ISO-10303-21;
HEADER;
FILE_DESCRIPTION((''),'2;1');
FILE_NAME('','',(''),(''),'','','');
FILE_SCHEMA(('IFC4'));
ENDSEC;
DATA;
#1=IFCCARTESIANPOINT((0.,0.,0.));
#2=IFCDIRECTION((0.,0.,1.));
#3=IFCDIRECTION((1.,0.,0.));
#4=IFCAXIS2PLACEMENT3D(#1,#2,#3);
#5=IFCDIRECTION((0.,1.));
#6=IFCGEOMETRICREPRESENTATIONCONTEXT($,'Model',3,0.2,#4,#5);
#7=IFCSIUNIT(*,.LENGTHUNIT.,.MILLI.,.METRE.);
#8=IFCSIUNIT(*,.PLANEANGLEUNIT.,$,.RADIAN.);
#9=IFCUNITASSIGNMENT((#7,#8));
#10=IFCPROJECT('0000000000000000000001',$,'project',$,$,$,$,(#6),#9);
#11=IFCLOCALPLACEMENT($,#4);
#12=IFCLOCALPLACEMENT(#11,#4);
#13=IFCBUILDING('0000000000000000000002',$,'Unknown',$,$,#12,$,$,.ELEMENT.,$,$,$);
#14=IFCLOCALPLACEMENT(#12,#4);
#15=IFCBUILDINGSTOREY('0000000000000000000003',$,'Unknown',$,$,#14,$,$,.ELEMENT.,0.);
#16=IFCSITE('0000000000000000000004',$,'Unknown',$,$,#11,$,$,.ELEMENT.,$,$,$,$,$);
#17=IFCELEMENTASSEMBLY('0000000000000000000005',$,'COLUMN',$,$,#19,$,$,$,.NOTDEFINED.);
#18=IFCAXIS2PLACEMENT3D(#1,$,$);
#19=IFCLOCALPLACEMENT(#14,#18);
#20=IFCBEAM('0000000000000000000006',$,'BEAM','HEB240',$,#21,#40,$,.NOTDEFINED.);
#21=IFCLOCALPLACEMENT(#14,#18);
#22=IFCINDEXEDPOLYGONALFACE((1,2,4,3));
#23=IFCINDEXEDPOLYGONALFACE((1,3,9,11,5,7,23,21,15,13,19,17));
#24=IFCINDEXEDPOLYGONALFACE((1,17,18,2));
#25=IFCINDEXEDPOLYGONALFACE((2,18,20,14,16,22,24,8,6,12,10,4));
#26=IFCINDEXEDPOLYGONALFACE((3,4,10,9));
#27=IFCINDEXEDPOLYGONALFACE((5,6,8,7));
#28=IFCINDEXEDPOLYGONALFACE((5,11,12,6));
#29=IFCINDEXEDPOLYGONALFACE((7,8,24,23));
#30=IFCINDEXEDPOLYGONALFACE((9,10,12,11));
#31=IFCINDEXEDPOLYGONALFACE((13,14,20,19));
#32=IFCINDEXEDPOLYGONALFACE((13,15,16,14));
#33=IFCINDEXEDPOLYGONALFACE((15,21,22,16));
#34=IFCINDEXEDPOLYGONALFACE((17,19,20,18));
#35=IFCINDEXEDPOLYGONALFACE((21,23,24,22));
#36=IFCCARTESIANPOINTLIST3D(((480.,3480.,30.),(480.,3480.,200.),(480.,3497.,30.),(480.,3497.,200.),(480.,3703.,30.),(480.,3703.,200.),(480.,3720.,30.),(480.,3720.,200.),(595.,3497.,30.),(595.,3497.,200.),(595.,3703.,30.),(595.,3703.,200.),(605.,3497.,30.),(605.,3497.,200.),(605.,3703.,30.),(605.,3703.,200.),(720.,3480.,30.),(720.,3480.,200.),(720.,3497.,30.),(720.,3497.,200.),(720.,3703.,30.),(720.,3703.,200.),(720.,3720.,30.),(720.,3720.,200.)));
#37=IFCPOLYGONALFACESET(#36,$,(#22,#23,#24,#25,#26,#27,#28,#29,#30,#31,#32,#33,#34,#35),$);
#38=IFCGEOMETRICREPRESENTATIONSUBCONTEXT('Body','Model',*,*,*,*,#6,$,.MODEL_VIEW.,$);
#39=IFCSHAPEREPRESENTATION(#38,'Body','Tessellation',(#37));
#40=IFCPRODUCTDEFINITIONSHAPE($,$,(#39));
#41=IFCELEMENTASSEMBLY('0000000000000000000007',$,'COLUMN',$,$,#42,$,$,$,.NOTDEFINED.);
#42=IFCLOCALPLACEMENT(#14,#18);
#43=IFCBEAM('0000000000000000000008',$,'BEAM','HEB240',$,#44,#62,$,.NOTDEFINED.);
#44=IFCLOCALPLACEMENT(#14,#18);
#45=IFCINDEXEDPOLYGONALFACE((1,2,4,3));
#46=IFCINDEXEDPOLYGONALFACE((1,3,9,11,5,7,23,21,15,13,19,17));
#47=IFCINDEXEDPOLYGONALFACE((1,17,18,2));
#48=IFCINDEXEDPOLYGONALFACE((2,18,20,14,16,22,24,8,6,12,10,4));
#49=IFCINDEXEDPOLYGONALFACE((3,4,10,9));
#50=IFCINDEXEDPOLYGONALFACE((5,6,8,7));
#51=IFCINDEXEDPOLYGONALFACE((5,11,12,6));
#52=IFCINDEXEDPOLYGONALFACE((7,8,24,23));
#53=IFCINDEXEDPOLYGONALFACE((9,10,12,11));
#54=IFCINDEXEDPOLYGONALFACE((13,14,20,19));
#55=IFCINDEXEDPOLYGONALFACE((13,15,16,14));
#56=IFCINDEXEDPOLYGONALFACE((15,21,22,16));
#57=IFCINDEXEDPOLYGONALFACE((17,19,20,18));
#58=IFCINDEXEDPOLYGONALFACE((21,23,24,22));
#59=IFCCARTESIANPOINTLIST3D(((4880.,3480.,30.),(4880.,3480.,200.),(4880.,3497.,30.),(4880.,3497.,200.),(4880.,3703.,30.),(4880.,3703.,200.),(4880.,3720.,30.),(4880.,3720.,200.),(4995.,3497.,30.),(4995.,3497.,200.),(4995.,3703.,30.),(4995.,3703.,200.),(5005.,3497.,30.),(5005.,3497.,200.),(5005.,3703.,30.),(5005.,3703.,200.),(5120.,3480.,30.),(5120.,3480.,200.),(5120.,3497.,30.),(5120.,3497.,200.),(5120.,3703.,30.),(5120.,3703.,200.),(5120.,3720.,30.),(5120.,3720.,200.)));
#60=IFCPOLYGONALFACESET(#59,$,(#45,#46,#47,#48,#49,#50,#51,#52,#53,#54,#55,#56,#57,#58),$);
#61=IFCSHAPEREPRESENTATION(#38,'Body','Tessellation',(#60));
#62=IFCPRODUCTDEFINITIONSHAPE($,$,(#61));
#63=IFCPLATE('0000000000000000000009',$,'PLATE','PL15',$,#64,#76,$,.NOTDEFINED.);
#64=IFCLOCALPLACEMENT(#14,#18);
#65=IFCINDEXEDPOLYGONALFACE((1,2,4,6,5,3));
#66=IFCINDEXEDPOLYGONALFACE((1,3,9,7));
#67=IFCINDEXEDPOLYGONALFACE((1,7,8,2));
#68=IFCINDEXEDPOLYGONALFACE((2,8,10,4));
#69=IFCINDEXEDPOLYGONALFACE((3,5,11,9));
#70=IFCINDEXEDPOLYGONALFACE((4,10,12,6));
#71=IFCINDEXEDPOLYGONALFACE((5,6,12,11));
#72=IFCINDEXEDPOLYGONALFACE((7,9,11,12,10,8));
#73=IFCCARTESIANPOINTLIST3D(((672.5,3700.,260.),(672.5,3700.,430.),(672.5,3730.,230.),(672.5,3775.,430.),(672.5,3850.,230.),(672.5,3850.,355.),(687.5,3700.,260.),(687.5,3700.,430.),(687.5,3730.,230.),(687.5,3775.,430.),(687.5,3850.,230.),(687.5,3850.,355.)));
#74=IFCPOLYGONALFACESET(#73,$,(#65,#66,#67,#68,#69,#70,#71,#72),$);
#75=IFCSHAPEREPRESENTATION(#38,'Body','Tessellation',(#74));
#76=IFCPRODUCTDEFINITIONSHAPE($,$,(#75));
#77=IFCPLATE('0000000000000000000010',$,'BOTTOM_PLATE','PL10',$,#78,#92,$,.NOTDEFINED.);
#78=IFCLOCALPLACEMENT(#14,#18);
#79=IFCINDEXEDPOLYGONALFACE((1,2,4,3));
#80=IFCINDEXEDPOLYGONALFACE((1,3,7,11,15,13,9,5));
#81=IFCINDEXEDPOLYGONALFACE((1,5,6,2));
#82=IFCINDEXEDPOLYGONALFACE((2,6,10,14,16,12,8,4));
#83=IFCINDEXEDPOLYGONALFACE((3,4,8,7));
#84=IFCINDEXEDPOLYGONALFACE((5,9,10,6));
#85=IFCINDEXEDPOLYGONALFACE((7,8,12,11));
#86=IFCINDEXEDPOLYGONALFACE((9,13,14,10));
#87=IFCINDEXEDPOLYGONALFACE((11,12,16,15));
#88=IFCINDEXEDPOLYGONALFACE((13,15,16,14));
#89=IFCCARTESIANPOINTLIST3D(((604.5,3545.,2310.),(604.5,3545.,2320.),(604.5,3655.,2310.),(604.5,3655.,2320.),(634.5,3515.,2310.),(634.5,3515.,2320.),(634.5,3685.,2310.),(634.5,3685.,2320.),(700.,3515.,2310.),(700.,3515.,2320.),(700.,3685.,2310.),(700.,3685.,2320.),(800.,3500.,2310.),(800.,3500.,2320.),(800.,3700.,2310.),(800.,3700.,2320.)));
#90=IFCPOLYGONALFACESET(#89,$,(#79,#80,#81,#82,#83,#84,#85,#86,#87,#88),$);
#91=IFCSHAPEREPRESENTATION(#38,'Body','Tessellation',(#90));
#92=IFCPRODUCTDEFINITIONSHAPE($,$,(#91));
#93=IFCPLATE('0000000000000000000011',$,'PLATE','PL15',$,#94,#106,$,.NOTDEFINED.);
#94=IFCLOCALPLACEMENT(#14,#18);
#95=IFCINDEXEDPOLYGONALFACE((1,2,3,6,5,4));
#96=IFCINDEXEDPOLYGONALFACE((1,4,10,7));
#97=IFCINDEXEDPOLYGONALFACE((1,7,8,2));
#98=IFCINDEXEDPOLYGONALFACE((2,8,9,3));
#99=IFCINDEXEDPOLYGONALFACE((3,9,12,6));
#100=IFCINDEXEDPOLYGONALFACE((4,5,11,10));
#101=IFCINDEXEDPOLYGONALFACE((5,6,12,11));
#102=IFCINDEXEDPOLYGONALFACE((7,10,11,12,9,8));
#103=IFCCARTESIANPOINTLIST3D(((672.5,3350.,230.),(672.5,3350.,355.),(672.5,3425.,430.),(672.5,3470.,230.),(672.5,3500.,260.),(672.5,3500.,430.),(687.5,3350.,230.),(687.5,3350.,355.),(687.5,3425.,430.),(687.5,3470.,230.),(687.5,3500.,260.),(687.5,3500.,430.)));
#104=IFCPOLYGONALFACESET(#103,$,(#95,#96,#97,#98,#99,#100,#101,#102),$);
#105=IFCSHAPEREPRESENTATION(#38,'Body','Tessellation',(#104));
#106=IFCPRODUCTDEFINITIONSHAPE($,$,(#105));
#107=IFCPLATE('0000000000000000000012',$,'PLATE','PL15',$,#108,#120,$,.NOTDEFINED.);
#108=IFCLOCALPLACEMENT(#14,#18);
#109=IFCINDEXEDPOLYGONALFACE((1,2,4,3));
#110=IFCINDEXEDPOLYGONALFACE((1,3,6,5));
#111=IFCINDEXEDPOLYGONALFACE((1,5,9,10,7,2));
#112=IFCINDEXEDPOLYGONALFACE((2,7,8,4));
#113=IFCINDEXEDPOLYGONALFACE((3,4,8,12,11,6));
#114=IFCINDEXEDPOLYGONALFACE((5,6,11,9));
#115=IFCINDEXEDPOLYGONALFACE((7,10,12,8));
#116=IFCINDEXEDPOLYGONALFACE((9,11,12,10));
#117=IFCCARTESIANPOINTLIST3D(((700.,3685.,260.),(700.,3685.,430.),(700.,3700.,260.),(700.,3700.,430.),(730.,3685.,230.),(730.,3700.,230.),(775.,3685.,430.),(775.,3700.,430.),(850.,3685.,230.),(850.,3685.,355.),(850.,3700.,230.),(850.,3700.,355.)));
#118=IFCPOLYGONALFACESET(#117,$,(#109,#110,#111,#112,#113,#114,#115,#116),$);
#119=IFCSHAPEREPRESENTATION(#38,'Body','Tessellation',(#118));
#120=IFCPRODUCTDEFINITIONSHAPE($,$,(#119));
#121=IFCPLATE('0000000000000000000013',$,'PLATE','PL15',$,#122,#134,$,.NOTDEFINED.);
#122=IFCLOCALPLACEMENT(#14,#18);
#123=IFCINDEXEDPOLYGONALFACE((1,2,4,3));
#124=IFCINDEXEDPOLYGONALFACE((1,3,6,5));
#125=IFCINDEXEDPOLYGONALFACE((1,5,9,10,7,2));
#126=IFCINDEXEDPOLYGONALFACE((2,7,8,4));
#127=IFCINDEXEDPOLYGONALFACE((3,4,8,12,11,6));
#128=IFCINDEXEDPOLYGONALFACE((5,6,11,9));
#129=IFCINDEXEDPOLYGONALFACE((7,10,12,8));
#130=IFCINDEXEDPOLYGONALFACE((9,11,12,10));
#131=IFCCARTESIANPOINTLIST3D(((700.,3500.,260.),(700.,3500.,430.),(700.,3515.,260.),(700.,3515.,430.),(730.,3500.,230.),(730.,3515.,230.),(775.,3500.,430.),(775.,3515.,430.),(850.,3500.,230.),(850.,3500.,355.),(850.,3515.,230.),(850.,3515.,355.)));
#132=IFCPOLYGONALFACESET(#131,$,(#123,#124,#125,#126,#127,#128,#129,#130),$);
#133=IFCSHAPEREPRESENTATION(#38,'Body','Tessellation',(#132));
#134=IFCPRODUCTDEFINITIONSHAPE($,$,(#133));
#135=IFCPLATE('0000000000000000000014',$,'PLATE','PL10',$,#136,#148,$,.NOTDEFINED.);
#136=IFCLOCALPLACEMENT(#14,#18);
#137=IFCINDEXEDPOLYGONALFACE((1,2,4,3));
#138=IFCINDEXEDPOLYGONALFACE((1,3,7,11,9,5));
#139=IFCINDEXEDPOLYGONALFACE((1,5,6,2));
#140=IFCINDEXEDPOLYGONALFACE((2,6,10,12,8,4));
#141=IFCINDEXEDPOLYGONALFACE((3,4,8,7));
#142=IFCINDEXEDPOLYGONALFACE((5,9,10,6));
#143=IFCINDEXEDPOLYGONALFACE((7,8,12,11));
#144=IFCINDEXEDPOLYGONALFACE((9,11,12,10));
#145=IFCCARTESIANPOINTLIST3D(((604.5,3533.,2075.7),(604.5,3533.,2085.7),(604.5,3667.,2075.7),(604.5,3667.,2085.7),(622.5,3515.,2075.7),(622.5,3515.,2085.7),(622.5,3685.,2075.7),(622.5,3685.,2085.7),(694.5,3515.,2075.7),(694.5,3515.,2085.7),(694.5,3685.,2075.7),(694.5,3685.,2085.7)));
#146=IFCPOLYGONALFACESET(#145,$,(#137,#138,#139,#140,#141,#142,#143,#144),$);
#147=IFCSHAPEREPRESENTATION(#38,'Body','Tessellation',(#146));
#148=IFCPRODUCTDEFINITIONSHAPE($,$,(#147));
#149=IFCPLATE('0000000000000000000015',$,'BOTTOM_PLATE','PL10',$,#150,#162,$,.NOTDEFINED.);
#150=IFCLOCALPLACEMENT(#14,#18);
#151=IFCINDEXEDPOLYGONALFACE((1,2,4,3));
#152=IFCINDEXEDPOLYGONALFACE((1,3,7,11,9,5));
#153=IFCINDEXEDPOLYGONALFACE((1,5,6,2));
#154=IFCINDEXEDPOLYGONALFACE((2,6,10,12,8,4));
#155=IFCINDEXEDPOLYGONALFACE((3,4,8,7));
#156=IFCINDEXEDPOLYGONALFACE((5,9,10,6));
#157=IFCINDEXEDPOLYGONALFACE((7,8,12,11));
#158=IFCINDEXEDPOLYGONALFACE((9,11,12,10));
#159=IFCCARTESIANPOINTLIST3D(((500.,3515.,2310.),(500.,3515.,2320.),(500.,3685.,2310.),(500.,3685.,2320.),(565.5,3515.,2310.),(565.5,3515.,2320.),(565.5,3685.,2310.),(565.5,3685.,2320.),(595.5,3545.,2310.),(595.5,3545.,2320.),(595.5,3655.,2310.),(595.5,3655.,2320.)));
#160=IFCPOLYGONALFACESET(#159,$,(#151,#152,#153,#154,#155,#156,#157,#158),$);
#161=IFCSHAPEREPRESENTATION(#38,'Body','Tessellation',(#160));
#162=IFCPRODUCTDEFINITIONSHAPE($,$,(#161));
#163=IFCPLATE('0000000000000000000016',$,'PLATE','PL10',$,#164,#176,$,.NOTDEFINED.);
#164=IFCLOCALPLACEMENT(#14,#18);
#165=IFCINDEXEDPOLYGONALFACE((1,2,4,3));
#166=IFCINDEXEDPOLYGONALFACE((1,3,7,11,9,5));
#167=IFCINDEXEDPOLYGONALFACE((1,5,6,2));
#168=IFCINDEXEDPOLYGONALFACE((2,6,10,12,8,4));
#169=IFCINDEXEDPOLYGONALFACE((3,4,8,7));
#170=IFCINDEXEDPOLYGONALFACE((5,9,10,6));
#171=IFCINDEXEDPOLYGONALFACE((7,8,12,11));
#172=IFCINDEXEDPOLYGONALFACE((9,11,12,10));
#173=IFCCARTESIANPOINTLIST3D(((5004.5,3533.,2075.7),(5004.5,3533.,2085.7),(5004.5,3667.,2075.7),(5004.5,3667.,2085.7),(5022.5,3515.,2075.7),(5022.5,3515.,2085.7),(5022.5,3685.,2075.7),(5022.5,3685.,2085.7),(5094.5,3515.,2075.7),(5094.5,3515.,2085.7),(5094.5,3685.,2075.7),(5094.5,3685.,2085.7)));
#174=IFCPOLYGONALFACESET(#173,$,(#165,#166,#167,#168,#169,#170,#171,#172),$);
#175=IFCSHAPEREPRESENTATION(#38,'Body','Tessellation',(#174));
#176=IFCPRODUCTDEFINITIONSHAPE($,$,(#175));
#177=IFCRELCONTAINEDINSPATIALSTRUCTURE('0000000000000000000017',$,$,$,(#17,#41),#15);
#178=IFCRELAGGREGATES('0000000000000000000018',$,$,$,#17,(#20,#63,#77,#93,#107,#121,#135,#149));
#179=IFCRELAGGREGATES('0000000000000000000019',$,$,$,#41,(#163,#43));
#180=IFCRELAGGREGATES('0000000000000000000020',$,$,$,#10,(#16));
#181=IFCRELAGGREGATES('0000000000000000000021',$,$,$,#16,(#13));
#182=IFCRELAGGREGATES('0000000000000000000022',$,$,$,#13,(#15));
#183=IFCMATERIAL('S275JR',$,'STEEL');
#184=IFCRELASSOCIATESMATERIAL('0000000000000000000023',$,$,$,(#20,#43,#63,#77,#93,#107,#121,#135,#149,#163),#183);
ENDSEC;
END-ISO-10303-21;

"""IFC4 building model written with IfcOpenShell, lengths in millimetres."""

from ifc_helpers import new_model, si_unit, direction, frame, origin_with_axes, place, context, subcontext, project, spatial, line, indexed_curve, outline, extrude, material, element, aggregate, save


model = new_model("IFC4")

# Units and contexts
model_context = context("Model", 3, precision=0.2, world=origin_with_axes(), true_north=direction((0.0, 1.0)))
body_context = subcontext(model_context, "Body", "Model", "MODEL_VIEW")
ifc_project = project(units=[si_unit("LENGTHUNIT", "METRE", prefix="MILLI"), si_unit("PLANEANGLEUNIT", "RADIAN")], contexts=[model_context])

# Site, building, storey
site_placement = place(None, origin_with_axes())
site = spatial("IfcSite", under=ifc_project, at=site_placement, Name="Unknown", CompositionType="ELEMENT")
building_placement = place(site_placement, origin_with_axes())
building = spatial("IfcBuilding", under=site, at=building_placement, Name="Unknown", CompositionType="ELEMENT")
storey_placement = place(building_placement, origin_with_axes())
storey = spatial("IfcBuildingStorey", under=building, at=storey_placement, Name="Unknown", CompositionType="ELEMENT", Elevation=0.0)

# Element assemblies, beams
assembly_1_placement = place(storey_placement, frame((600.0, 3600.0, 200.0), z_axis=(-1.0, 0.0, 0.0), x_axis=(0.0, 0.0, 1.0)))
assembly_1 = element("IfcElementAssembly", 1, at=assembly_1_placement, inside=storey, Name="COLUMN", PredefinedType="NOTDEFINED")
ifc_material_1 = material(Name="S275JR", Category="STEEL")
beam_1_placement = place(assembly_1_placement, frame((0.0, 0.0, 0.0), z_axis=(0.0, -0.000002, -1.0), x_axis=(-1.0, 0.0, 0.0)))
beam_1 = element("IfcBeam", 2, at=beam_1_placement, material=ifc_material_1, Name="BEAM", Description="HEB240", PredefinedType="NOTDEFINED", context=body_context, shape_type="SolidModel", body=[
    extrude(outline(indexed_curve([(-120.0, -120.0), (120.0, -120.0), (120.0, -103.0), (5.0, -103.0), (5.0, 103.0), (120.0, 103.0), (120.0, 120.0), (-120.0, 120.0), (-120.0, 103.0), (-5.0, 103.0), (-5.0, -103.0), (-120.0, -103.0)], segments=[line(1, 2, 3, 4, 5, 6, 7, 8, 9, 10, 11, 12, 1)])), frame((0.0, 0.0, 0.0), z_axis=(-1.0, 0.0, 0.0), x_axis=(0.0, 0.0, 1.0)), (0.0, -0.000002, -1.0), 170.0),
])
assembly_2_placement = place(storey_placement, frame((5000.0, 3600.0, 200.0), z_axis=(-1.0, 0.0, 0.0), x_axis=(0.0, 0.0, 1.0)))
assembly_2 = element("IfcElementAssembly", 3, at=assembly_2_placement, inside=storey, Name="COLUMN", PredefinedType="NOTDEFINED")
beam_2_placement = place(assembly_2_placement, frame((0.0, 0.0, 0.0), z_axis=(0.0, -0.000002, -1.0), x_axis=(-1.0, 0.0, 0.0)))
beam_2 = element("IfcBeam", 4, at=beam_2_placement, material=ifc_material_1, Name="BEAM", Description="HEB240", PredefinedType="NOTDEFINED", context=body_context, shape_type="SolidModel", body=[
    extrude(outline(indexed_curve([(-120.0, -120.0), (120.0, -120.0), (120.0, -103.0), (5.0, -103.0), (5.0, 103.0), (120.0, 103.0), (120.0, 120.0), (-120.0, 120.0), (-120.0, 103.0), (-5.0, 103.0), (-5.0, -103.0), (-120.0, -103.0)], segments=[line(1, 2, 3, 4, 5, 6, 7, 8, 9, 10, 11, 12, 1)])), frame((0.0, 0.0, 0.0), z_axis=(-1.0, 0.0, 0.0), x_axis=(0.0, 0.0, 1.0)), (0.0, -0.000002, -1.0), 170.0),
])

# Plates
plate_1_placement = place(assembly_1_placement, frame((60.0, 100.0, -80.0), z_axis=(0.0, -0.000002, -1.0), x_axis=(-0.707113, 0.707101, 0.0)))
plate_1 = element("IfcPlate", 5, at=plate_1_placement, material=ifc_material_1, Name="PLATE", Description="PL15", PredefinedType="NOTDEFINED", context=body_context, shape_type="SolidModel", body=[
    extrude(outline(indexed_curve([(0.0, 0.0), (42.4, 0.0), (127.3, 84.9), (38.9, 173.2), (-67.2, 173.2), (-120.2, 120.2)], segments=[line(1, 2, 3, 4, 5, 6, 1)])), frame((0.0, 0.0, 7.5), z_axis=(0.0, 0.0, 1.0), x_axis=(1.0, 0.0, 0.0)), (0.0, -0.000002, -1.0), 15.0),
])
plate_2_placement = place(assembly_1_placement, frame((2115.0, 85.0, -4.5), z_axis=(1.0, 0.0, 0.0), x_axis=(0.0, -1.0, 0.000002)))
plate_2 = element("IfcPlate", 6, at=plate_2_placement, material=ifc_material_1, Name="BOTTOM_PLATE", Description="PL10", PredefinedType="NOTDEFINED", context=body_context, shape_type="SolidModel", body=[
    extrude(outline(indexed_curve([(0.0, 30.0), (30.0, 0.0), (140.0, 0.0), (170.0, 30.0), (170.0, 95.5), (185.0, 195.5), (-15.0, 195.5), (0.0, 95.5)], segments=[line(1, 2, 3, 4, 5, 6, 7, 8, 1)])), frame((0.0, 0.0, 5.0), z_axis=(0.0, 0.0, 1.0), x_axis=(1.0, 0.0, 0.0)), (0.0, -0.000002, -1.0), 10.0),
])
plate_3_placement = place(assembly_1_placement, frame((60.0, -100.0, -80.0), z_axis=(0.0, 0.0, 1.0), x_axis=(-0.707116, -0.707097, 0.0)))
plate_3 = element("IfcPlate", 7, at=plate_3_placement, material=ifc_material_1, Name="PLATE", Description="PL15", PredefinedType="NOTDEFINED", context=body_context, shape_type="SolidModel", body=[
    extrude(outline(indexed_curve([(0.0, 0.0), (42.4, 0.0), (127.3, 84.9), (38.9, 173.2), (-67.2, 173.2), (-120.2, 120.2)], segments=[line(1, 2, 3, 4, 5, 6, 1)])), frame((0.0, 0.0, 7.5), z_axis=(0.0, 0.0, 1.0), x_axis=(1.0, 0.0, 0.0)), (0.0, -0.000002, -1.0), 15.0),
])
plate_4_placement = place(assembly_1_placement, frame((60.0, 92.5, -100.0), z_axis=(0.0, -1.0, 0.000002), x_axis=(-0.707107, 0.0, -0.707107)))
plate_4 = element("IfcPlate", 8, at=plate_4_placement, material=ifc_material_1, Name="PLATE", Description="PL15", PredefinedType="NOTDEFINED", context=body_context, shape_type="SolidModel", body=[
    extrude(outline(indexed_curve([(0.0, 0.0), (42.4, 0.0), (127.3, 84.9), (38.9, 173.2), (-67.2, 173.2), (-120.2, 120.2)], segments=[line(1, 2, 3, 4, 5, 6, 1)])), frame((0.0, 0.0, 7.5), z_axis=(0.0, 0.0, 1.0), x_axis=(1.0, 0.0, 0.0)), (0.0, -0.000002, -1.0), 15.0),
])
plate_5_placement = place(assembly_1_placement, frame((60.0, -92.5, -100.0), z_axis=(0.0, -1.0, 0.000002), x_axis=(-0.707107, 0.0, -0.707107)))
plate_5 = element("IfcPlate", 9, at=plate_5_placement, material=ifc_material_1, Name="PLATE", Description="PL15", PredefinedType="NOTDEFINED", context=body_context, shape_type="SolidModel", body=[
    extrude(outline(indexed_curve([(0.0, 0.0), (42.4, 0.0), (127.3, 84.9), (38.9, 173.2), (-67.2, 173.2), (-120.2, 120.2)], segments=[line(1, 2, 3, 4, 5, 6, 1)])), frame((0.0, 0.0, 7.5), z_axis=(0.0, 0.0, 1.0), x_axis=(1.0, 0.0, 0.0)), (0.0, -0.000002, -1.0), 15.0),
])
plate_6_placement = place(assembly_1_placement, frame((1880.7, -85.0, -94.5), z_axis=(-1.0, 0.0, 0.0), x_axis=(0.0, 0.0, 1.0)))
plate_6 = element("IfcPlate", 10, at=plate_6_placement, material=ifc_material_1, Name="PLATE", Description="PL10", PredefinedType="NOTDEFINED", context=body_context, shape_type="SolidModel", body=[
    extrude(outline(indexed_curve([(0.0, 0.0), (72.0, 0.0), (90.0, 18.0), (90.0, 152.0), (72.0, 170.0), (0.0, 170.0)], segments=[line(1, 2, 3, 4, 5, 6, 1)])), frame((0.0, 0.0, 5.0), z_axis=(0.0, 0.0, 1.0), x_axis=(1.0, 0.0, 0.0)), (0.0, -0.000002, -1.0), 10.0),
])
plate_7_placement = place(assembly_1_placement, frame((2115.0, 85.0, 4.5), z_axis=(1.0, 0.0, 0.0), x_axis=(0.0, 0.0, 1.0)))
plate_7 = element("IfcPlate", 11, at=plate_7_placement, material=ifc_material_1, Name="BOTTOM_PLATE", Description="PL10", PredefinedType="NOTDEFINED", context=body_context, shape_type="SolidModel", body=[
    extrude(outline(indexed_curve([(0.0, 30.0), (30.0, 0.0), (95.5, 0.0), (95.5, 170.0), (30.0, 170.0), (0.0, 140.0)], segments=[line(1, 2, 3, 4, 5, 6, 1)])), frame((0.0, 0.0, 5.0), z_axis=(0.0, 0.0, 1.0), x_axis=(1.0, 0.0, 0.0)), (0.0, -0.000002, -1.0), 10.0),
])
plate_8_placement = place(assembly_2_placement, frame((1880.7, -85.0, -94.5), z_axis=(-1.0, 0.0, 0.0), x_axis=(0.0, 0.0, 1.0)))
plate_8 = element("IfcPlate", 12, at=plate_8_placement, material=ifc_material_1, Name="PLATE", Description="PL10", PredefinedType="NOTDEFINED", context=body_context, shape_type="SolidModel", body=[
    extrude(outline(indexed_curve([(0.0, 0.0), (72.0, 0.0), (90.0, 18.0), (90.0, 152.0), (72.0, 170.0), (0.0, 170.0)], segments=[line(1, 2, 3, 4, 5, 6, 1)])), frame((0.0, 0.0, 5.0), z_axis=(0.0, 0.0, 1.0), x_axis=(1.0, 0.0, 0.0)), (0.0, -0.000002, -1.0), 10.0),
])

aggregate(assembly_1, [beam_1, plate_1, plate_2, plate_3, plate_4, plate_5, plate_6, plate_7])
aggregate(assembly_2, [plate_8, beam_2])

save(model, "model.ifc")
